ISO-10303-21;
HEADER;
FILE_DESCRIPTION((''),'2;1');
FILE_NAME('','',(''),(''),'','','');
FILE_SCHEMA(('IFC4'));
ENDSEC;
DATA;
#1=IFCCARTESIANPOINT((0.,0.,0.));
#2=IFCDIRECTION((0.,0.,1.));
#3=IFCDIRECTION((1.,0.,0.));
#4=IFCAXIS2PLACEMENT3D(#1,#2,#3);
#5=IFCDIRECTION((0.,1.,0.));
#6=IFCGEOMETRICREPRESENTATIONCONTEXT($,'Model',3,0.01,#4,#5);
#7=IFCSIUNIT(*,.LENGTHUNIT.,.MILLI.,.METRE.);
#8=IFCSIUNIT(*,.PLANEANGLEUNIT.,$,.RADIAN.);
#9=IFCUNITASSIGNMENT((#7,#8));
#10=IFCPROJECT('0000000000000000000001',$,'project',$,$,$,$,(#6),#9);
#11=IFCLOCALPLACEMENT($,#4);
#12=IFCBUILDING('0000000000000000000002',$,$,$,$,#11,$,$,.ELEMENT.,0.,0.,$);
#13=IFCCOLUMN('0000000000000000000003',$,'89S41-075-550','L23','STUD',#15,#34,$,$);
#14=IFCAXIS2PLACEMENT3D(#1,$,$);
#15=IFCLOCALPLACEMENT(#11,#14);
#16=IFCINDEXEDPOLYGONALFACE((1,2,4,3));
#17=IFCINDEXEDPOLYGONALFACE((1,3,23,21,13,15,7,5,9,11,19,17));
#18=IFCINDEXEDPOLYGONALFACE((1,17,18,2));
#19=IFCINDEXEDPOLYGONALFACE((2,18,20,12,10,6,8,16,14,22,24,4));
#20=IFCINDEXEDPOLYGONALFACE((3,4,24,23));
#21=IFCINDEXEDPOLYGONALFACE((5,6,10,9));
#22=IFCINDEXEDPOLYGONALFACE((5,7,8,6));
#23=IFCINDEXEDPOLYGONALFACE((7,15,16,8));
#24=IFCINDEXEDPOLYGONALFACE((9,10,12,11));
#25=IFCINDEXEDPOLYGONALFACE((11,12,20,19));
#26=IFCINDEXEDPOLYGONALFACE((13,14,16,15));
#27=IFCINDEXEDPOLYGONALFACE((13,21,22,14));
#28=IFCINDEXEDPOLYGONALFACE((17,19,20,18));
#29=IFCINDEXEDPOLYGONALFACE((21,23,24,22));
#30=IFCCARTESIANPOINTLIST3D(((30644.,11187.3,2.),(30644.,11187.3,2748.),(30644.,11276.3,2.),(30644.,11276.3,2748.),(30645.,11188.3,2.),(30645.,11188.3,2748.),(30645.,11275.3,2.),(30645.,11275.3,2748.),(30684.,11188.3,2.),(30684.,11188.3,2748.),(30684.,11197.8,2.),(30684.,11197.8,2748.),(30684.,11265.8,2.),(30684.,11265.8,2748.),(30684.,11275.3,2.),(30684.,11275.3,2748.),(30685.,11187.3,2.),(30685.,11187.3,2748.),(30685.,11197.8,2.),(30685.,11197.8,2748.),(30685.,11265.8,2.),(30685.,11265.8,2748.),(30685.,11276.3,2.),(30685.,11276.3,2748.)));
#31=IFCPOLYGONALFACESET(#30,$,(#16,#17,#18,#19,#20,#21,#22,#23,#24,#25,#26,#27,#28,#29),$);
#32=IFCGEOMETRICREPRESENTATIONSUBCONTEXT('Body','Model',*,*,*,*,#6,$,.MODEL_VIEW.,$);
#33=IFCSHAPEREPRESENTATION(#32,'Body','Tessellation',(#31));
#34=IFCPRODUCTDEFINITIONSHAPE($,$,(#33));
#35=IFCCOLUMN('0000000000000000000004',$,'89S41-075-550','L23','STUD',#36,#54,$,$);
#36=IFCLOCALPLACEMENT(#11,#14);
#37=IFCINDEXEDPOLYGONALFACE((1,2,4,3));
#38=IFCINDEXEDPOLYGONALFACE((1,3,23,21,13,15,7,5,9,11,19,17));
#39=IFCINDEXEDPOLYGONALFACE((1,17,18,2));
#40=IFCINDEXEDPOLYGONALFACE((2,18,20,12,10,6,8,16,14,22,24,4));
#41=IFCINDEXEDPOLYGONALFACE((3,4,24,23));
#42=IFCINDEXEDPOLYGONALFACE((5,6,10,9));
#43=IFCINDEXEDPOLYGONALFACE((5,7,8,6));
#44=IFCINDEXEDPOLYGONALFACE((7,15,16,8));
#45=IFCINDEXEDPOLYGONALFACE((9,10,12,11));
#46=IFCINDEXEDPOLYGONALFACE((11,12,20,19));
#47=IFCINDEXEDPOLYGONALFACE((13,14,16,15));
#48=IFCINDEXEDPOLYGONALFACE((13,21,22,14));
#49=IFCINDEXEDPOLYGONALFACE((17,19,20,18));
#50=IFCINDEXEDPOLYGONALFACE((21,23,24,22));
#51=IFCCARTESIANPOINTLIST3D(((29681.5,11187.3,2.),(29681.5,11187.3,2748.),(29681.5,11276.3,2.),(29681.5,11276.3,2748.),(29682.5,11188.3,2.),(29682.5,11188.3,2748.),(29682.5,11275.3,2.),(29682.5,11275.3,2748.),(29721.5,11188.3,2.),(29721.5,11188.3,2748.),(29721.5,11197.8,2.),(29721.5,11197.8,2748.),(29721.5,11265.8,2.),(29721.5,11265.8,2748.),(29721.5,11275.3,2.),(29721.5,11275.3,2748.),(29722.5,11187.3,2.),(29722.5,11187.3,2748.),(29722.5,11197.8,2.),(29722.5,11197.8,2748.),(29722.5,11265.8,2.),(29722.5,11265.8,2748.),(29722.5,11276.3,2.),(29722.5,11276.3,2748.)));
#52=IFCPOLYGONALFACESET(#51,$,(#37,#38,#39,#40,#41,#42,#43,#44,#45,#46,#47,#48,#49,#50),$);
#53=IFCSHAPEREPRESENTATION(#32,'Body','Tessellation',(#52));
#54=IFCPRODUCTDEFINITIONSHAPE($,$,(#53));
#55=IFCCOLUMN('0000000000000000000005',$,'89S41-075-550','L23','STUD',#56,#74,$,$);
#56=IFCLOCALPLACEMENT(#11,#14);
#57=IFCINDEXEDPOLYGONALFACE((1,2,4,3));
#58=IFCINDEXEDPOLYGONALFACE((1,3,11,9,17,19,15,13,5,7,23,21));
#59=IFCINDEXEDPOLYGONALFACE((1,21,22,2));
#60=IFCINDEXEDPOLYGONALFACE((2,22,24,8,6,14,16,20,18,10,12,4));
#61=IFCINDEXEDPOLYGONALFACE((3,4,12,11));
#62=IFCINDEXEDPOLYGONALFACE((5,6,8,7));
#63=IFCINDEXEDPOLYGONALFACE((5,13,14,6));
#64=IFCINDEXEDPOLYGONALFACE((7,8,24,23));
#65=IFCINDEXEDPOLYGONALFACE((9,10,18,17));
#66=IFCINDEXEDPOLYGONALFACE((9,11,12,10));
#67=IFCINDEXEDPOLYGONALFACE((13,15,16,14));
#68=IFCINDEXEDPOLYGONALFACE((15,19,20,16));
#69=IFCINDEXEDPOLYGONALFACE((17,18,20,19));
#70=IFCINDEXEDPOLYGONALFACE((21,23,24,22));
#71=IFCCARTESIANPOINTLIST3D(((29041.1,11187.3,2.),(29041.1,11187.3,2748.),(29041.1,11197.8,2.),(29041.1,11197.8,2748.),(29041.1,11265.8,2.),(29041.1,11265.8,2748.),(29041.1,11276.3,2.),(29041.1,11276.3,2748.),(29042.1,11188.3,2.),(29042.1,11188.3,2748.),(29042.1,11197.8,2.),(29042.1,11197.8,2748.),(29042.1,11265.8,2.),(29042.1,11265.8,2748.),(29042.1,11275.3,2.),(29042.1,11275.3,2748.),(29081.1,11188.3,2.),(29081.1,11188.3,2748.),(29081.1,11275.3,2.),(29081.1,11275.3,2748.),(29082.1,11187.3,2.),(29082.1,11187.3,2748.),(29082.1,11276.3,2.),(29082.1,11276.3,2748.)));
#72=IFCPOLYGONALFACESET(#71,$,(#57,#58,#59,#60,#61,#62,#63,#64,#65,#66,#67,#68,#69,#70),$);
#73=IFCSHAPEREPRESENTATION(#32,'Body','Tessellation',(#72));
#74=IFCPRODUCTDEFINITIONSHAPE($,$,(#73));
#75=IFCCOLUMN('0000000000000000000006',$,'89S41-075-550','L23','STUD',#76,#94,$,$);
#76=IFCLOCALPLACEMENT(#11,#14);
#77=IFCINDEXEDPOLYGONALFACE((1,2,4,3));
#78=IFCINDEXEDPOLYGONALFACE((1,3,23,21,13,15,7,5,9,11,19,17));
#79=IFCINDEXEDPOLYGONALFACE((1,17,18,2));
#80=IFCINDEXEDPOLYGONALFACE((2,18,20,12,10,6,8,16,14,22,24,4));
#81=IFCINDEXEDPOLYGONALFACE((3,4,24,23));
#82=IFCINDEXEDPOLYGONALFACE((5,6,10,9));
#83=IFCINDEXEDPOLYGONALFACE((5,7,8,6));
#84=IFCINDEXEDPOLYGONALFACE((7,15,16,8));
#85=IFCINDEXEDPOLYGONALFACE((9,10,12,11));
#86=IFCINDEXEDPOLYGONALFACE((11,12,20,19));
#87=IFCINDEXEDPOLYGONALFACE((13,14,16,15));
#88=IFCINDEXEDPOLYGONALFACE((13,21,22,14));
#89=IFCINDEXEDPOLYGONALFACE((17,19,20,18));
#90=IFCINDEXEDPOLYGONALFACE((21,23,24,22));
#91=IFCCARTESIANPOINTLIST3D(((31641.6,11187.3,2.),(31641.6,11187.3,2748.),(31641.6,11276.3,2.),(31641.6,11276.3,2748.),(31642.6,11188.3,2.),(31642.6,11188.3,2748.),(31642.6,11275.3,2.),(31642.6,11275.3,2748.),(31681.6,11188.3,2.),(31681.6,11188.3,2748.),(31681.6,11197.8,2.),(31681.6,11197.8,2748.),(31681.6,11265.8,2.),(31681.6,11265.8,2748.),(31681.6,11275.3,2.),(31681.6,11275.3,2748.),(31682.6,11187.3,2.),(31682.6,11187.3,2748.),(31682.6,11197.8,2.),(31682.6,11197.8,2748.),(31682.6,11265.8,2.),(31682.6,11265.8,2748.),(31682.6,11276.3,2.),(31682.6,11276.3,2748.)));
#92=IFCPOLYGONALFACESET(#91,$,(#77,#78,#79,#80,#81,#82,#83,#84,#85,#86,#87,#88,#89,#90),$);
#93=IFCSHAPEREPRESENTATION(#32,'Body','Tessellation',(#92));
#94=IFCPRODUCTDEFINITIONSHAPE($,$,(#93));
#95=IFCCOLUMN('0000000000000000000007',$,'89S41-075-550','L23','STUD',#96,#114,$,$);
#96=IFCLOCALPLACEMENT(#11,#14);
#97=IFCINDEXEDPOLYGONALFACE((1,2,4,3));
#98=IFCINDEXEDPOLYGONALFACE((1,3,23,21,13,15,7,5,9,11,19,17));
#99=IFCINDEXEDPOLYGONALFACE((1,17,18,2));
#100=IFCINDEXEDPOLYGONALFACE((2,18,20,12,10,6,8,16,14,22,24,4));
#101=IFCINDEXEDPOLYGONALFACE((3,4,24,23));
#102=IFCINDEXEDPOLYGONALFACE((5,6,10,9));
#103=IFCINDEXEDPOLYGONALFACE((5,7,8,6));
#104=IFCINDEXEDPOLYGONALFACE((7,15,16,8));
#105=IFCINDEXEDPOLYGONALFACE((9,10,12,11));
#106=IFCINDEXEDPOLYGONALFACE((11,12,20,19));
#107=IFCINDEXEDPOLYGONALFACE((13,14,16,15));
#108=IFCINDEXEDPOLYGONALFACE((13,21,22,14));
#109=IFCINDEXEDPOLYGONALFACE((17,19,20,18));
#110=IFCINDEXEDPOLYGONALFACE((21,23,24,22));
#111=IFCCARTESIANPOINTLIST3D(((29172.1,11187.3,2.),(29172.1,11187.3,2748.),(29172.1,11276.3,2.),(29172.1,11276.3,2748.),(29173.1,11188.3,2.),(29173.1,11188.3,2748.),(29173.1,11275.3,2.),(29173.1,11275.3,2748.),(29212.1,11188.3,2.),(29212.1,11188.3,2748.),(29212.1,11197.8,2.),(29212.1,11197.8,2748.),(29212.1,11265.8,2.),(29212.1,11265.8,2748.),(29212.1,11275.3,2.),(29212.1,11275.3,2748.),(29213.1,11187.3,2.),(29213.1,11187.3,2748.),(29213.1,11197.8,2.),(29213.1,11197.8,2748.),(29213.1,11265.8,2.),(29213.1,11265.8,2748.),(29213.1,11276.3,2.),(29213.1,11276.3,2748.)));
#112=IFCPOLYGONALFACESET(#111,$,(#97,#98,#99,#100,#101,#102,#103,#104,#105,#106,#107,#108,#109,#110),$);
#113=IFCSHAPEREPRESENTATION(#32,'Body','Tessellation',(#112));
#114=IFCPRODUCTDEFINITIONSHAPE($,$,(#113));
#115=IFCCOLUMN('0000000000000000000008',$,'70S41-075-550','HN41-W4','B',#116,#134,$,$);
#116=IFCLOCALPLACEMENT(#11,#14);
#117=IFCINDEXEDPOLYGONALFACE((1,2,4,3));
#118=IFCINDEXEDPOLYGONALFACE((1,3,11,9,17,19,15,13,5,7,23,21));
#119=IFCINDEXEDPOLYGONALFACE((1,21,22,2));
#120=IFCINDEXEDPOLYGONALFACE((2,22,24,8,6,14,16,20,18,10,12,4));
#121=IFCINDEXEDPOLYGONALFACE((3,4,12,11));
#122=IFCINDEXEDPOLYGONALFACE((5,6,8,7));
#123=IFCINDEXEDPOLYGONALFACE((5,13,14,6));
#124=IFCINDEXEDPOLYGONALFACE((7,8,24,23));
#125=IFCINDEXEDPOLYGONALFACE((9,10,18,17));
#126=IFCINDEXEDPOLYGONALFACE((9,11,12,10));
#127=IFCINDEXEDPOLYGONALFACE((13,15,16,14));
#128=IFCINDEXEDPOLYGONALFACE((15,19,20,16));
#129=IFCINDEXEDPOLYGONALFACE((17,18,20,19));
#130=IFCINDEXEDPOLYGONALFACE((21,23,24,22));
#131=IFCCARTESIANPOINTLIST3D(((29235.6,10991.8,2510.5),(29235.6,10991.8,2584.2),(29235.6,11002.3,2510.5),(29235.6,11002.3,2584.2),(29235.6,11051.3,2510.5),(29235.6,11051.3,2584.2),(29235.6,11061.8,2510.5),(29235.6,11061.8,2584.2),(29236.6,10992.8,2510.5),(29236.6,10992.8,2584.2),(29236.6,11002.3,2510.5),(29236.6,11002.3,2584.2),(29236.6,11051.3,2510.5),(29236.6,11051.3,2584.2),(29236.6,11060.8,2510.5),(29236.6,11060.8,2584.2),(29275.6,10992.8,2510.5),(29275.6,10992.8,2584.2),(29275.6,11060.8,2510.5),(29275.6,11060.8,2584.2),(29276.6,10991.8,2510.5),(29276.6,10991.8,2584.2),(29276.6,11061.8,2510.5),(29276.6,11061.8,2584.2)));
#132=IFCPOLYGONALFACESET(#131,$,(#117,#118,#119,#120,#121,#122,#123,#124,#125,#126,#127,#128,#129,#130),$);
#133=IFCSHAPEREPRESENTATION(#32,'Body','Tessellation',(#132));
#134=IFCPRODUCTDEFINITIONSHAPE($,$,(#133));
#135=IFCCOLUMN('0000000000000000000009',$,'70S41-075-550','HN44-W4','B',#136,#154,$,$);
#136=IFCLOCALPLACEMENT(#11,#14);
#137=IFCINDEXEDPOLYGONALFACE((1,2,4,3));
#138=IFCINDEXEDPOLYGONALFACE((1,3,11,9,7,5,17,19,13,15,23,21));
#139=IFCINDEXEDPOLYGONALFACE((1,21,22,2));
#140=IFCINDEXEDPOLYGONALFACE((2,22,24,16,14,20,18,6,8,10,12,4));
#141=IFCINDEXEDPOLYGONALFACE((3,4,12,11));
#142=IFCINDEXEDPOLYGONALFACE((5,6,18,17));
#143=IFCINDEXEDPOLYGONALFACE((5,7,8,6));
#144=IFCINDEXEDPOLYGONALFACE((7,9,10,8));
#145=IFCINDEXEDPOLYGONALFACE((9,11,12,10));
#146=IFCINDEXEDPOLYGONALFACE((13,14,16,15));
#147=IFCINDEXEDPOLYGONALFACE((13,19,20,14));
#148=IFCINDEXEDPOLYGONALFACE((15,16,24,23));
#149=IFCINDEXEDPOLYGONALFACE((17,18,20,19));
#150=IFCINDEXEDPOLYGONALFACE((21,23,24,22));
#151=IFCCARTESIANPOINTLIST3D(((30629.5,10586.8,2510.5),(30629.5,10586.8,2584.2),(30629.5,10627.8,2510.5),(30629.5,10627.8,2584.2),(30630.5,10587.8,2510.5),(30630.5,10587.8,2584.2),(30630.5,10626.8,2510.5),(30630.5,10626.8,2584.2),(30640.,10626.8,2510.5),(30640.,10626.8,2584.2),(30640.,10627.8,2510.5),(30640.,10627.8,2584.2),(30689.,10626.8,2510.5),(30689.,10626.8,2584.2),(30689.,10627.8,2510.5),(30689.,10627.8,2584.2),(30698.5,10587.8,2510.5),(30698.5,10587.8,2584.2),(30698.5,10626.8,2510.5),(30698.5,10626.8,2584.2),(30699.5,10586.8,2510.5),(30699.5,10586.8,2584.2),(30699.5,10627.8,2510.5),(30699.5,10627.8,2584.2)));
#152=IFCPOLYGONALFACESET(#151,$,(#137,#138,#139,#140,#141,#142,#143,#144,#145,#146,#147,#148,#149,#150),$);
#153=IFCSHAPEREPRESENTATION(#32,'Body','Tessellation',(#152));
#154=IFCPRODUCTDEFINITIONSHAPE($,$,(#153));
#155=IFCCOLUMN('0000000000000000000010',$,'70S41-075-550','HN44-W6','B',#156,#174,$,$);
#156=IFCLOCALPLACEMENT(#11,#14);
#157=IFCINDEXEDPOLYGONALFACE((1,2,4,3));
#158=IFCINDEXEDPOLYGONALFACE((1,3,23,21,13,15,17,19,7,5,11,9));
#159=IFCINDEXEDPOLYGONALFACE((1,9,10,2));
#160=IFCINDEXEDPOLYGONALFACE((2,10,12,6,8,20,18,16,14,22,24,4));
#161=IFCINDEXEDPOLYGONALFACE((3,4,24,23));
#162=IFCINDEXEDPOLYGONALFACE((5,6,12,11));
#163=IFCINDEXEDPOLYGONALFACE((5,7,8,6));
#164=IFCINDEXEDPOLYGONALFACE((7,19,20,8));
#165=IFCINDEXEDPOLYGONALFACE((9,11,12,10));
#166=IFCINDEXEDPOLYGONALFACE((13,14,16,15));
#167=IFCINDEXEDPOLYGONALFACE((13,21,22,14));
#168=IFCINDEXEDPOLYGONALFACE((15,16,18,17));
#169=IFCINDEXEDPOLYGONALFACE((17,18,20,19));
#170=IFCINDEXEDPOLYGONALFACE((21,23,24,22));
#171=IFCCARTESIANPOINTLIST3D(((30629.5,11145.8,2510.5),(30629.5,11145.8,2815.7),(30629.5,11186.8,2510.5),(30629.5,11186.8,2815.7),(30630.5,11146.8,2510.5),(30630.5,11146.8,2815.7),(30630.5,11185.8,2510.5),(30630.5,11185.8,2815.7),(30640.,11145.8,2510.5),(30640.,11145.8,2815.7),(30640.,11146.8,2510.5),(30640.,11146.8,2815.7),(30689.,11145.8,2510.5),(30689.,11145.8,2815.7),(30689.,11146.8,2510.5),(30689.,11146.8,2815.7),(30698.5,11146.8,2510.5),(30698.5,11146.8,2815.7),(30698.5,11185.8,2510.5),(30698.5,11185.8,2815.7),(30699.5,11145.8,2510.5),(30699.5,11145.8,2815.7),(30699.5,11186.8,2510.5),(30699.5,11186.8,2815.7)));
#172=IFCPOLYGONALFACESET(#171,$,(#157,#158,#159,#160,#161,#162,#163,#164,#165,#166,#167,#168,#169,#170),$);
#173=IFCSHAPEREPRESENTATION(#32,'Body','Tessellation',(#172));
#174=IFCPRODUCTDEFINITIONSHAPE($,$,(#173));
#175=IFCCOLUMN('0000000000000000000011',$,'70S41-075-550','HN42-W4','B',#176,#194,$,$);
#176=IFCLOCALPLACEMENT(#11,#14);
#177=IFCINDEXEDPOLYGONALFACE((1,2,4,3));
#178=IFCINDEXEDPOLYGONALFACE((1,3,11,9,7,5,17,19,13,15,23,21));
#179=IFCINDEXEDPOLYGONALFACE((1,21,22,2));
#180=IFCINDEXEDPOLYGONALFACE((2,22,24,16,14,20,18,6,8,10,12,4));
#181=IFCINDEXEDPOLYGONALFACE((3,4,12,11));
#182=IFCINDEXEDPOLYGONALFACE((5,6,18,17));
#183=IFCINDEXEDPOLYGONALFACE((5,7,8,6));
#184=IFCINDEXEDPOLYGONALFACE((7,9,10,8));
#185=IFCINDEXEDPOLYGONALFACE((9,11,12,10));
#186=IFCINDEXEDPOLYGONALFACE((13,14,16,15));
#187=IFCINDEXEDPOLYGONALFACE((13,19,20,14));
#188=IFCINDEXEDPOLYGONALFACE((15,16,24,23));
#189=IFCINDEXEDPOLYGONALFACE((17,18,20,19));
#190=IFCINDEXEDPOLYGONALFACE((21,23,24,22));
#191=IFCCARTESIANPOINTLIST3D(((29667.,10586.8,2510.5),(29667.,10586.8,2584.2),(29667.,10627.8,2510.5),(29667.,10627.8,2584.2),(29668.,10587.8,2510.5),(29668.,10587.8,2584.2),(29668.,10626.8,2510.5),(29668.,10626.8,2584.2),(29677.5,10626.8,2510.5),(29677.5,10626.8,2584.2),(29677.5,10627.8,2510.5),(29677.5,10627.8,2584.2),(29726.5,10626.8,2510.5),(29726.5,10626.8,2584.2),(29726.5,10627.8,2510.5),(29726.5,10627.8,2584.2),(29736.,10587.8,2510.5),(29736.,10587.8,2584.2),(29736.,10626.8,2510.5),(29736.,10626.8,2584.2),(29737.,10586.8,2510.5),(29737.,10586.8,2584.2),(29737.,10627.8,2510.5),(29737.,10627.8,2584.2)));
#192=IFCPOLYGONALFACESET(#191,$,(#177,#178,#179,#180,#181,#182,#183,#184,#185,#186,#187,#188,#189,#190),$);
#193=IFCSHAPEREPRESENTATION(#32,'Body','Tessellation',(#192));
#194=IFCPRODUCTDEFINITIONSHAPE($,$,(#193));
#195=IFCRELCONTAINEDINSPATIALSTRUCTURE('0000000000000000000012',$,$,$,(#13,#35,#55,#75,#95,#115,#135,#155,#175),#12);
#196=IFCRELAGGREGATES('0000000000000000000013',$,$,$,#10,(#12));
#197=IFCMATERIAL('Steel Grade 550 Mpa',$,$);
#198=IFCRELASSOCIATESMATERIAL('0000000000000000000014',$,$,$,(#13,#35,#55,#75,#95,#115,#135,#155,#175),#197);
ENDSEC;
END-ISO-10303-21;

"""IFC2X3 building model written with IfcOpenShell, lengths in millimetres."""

from ifc_helpers import new_model, si_unit, direction, frame, origin, origin_with_axes, origin_2d_with_axis, place, context, subcontext, project, spatial, c_section, extrude, source, transform, mapped, material, element, save


model = new_model("IFC2X3")

# Units and contexts
model_context = context("Model", 3, precision=0.01, world=origin_with_axes(), true_north=direction((0.0, 1.0, 0.0)))
body_context = subcontext(model_context, "Body", "Model", "MODEL_VIEW")
ifc_project = project(units=[si_unit("LENGTHUNIT", "METRE", prefix="MILLI"), si_unit("PLANEANGLEUNIT", "RADIAN")], contexts=[model_context])

# Building
building_placement = place(None, origin_with_axes())
building = spatial("IfcBuilding", under=ifc_project, at=building_placement, CompositionType="ELEMENT", ElevationOfRefHeight=0.0, ElevationOfTerrain=0.0)

# Columns
ifc_material = material(Name="Steel Grade 550 Mpa")
shared_shape_1 = source(origin(), body_context, "Body", "SweptSolid", [
    extrude(c_section(Depth=89.0, Width=41.0, WallThickness=1.0, Girth=10.5, at=origin_2d_with_axis()), origin_with_axes(), (0.0, 0.0, 1.0), 2746.0),
])
column_1_placement = place(None, frame((30664.5, 11231.8, 2.0), z_axis=(0.0, 0.0, 1.0), x_axis=(1.0, 0.0, 0.0)))
element("IfcColumn", 1, at=column_1_placement, inside=building, material=ifc_material, Name="89S41-075-550", Description="L23", ObjectType="STUD", context=body_context, shape_type="MappedRepresentation", body=[
    mapped(shared_shape_1, transform((0.0, 0.0, 0.0), scale=1.0)),
])
shared_shape_2 = source(origin(), body_context, "Body", "SweptSolid", [
    extrude(c_section(Depth=89.0, Width=41.0, WallThickness=1.0, Girth=10.5, at=origin_2d_with_axis()), origin_with_axes(), (0.0, 0.0, 1.0), 2746.0),
])
column_2_placement = place(None, frame((29702.0, 11231.8, 2.0), z_axis=(0.0, 0.0, 1.0), x_axis=(1.0, 0.0, 0.0)))
element("IfcColumn", 2, at=column_2_placement, inside=building, material=ifc_material, Name="89S41-075-550", Description="L23", ObjectType="STUD", context=body_context, shape_type="MappedRepresentation", body=[
    mapped(shared_shape_2, transform((0.0, 0.0, 0.0), scale=1.0)),
])
shared_shape_3 = source(origin(), body_context, "Body", "SweptSolid", [
    extrude(c_section(Depth=89.0, Width=41.0, WallThickness=1.0, Girth=10.5, at=origin_2d_with_axis()), origin_with_axes(), (0.0, 0.0, 1.0), 2746.0),
])
column_3_placement = place(None, frame((29061.6, 11231.8, 2.0), z_axis=(0.0, 0.0, 1.0), x_axis=(-1.0, 0.0, 0.0)))
element("IfcColumn", 3, at=column_3_placement, inside=building, material=ifc_material, Name="89S41-075-550", Description="L23", ObjectType="STUD", context=body_context, shape_type="MappedRepresentation", body=[
    mapped(shared_shape_3, transform((0.0, 0.0, 0.0), scale=1.0)),
])
shared_shape_4 = source(origin(), body_context, "Body", "SweptSolid", [
    extrude(c_section(Depth=89.0, Width=41.0, WallThickness=1.0, Girth=10.5, at=origin_2d_with_axis()), origin_with_axes(), (0.0, 0.0, 1.0), 2746.0),
])
column_4_placement = place(None, frame((31662.1, 11231.8, 2.0), z_axis=(0.0, 0.0, 1.0), x_axis=(1.0, 0.0, 0.0)))
element("IfcColumn", 4, at=column_4_placement, inside=building, material=ifc_material, Name="89S41-075-550", Description="L23", ObjectType="STUD", context=body_context, shape_type="MappedRepresentation", body=[
    mapped(shared_shape_4, transform((0.0, 0.0, 0.0), scale=1.0)),
])
shared_shape_5 = source(origin(), body_context, "Body", "SweptSolid", [
    extrude(c_section(Depth=89.0, Width=41.0, WallThickness=1.0, Girth=10.5, at=origin_2d_with_axis()), origin_with_axes(), (0.0, 0.0, 1.0), 2746.0),
])
column_5_placement = place(None, frame((29192.6, 11231.8, 2.0), z_axis=(0.0, 0.0, 1.0), x_axis=(1.0, 0.0, 0.0)))
element("IfcColumn", 5, at=column_5_placement, inside=building, material=ifc_material, Name="89S41-075-550", Description="L23", ObjectType="STUD", context=body_context, shape_type="MappedRepresentation", body=[
    mapped(shared_shape_5, transform((0.0, 0.0, 0.0), scale=1.0)),
])
shared_shape_6 = source(origin(), body_context, "Body", "SweptSolid", [
    extrude(c_section(Depth=70.0, Width=41.0, WallThickness=1.0, Girth=10.5, at=origin_2d_with_axis()), origin_with_axes(), (0.0, 0.0, 1.0), 73.7),
])
column_6_placement = place(None, frame((29256.1, 11026.8, 2584.2), z_axis=(0.0, 0.0, -1.0), x_axis=(-1.0, 0.0, 0.0)))
element("IfcColumn", 6, at=column_6_placement, inside=building, material=ifc_material, Name="70S41-075-550", Description="HN41-W4", ObjectType="B", context=body_context, shape_type="MappedRepresentation", body=[
    mapped(shared_shape_6, transform((0.0, 0.0, 0.0), scale=1.0)),
])
shared_shape_7 = source(origin(), body_context, "Body", "SweptSolid", [
    extrude(c_section(Depth=70.0, Width=41.0, WallThickness=1.0, Girth=10.5, at=origin_2d_with_axis()), origin_with_axes(), (0.0, 0.0, 1.0), 73.7),
])
column_7_placement = place(None, frame((30664.5, 10607.3, 2584.2), z_axis=(0.0, 0.0, -1.0), x_axis=(0.0, 1.0, 0.0)))
element("IfcColumn", 7, at=column_7_placement, inside=building, material=ifc_material, Name="70S41-075-550", Description="HN44-W4", ObjectType="B", context=body_context, shape_type="MappedRepresentation", body=[
    mapped(shared_shape_7, transform((0.0, 0.0, 0.0), scale=1.0)),
])
shared_shape_8 = source(origin(), body_context, "Body", "SweptSolid", [
    extrude(c_section(Depth=70.0, Width=41.0, WallThickness=1.0, Girth=10.5, at=origin_2d_with_axis()), origin_with_axes(), (0.0, 0.0, 1.0), 305.2),
])
column_8_placement = place(None, frame((30664.5, 11166.3, 2510.5), z_axis=(0.0, 0.0, 1.0), x_axis=(0.0, -1.0, 0.0)))
element("IfcColumn", 8, at=column_8_placement, inside=building, material=ifc_material, Name="70S41-075-550", Description="HN44-W6", ObjectType="B", context=body_context, shape_type="MappedRepresentation", body=[
    mapped(shared_shape_8, transform((0.0, 0.0, 0.0), scale=1.0)),
])
shared_shape_9 = source(origin(), body_context, "Body", "SweptSolid", [
    extrude(c_section(Depth=70.0, Width=41.0, WallThickness=1.0, Girth=10.5, at=origin_2d_with_axis()), origin_with_axes(), (0.0, 0.0, 1.0), 73.7),
])
column_9_placement = place(None, frame((29702.0, 10607.3, 2584.2), z_axis=(0.0, 0.0, -1.0), x_axis=(0.0, 1.0, 0.0)))
element("IfcColumn", 9, at=column_9_placement, inside=building, material=ifc_material, Name="70S41-075-550", Description="HN42-W4", ObjectType="B", context=body_context, shape_type="MappedRepresentation", body=[
    mapped(shared_shape_9, transform((0.0, 0.0, 0.0), scale=1.0)),
])

save(model, "model.ifc")
